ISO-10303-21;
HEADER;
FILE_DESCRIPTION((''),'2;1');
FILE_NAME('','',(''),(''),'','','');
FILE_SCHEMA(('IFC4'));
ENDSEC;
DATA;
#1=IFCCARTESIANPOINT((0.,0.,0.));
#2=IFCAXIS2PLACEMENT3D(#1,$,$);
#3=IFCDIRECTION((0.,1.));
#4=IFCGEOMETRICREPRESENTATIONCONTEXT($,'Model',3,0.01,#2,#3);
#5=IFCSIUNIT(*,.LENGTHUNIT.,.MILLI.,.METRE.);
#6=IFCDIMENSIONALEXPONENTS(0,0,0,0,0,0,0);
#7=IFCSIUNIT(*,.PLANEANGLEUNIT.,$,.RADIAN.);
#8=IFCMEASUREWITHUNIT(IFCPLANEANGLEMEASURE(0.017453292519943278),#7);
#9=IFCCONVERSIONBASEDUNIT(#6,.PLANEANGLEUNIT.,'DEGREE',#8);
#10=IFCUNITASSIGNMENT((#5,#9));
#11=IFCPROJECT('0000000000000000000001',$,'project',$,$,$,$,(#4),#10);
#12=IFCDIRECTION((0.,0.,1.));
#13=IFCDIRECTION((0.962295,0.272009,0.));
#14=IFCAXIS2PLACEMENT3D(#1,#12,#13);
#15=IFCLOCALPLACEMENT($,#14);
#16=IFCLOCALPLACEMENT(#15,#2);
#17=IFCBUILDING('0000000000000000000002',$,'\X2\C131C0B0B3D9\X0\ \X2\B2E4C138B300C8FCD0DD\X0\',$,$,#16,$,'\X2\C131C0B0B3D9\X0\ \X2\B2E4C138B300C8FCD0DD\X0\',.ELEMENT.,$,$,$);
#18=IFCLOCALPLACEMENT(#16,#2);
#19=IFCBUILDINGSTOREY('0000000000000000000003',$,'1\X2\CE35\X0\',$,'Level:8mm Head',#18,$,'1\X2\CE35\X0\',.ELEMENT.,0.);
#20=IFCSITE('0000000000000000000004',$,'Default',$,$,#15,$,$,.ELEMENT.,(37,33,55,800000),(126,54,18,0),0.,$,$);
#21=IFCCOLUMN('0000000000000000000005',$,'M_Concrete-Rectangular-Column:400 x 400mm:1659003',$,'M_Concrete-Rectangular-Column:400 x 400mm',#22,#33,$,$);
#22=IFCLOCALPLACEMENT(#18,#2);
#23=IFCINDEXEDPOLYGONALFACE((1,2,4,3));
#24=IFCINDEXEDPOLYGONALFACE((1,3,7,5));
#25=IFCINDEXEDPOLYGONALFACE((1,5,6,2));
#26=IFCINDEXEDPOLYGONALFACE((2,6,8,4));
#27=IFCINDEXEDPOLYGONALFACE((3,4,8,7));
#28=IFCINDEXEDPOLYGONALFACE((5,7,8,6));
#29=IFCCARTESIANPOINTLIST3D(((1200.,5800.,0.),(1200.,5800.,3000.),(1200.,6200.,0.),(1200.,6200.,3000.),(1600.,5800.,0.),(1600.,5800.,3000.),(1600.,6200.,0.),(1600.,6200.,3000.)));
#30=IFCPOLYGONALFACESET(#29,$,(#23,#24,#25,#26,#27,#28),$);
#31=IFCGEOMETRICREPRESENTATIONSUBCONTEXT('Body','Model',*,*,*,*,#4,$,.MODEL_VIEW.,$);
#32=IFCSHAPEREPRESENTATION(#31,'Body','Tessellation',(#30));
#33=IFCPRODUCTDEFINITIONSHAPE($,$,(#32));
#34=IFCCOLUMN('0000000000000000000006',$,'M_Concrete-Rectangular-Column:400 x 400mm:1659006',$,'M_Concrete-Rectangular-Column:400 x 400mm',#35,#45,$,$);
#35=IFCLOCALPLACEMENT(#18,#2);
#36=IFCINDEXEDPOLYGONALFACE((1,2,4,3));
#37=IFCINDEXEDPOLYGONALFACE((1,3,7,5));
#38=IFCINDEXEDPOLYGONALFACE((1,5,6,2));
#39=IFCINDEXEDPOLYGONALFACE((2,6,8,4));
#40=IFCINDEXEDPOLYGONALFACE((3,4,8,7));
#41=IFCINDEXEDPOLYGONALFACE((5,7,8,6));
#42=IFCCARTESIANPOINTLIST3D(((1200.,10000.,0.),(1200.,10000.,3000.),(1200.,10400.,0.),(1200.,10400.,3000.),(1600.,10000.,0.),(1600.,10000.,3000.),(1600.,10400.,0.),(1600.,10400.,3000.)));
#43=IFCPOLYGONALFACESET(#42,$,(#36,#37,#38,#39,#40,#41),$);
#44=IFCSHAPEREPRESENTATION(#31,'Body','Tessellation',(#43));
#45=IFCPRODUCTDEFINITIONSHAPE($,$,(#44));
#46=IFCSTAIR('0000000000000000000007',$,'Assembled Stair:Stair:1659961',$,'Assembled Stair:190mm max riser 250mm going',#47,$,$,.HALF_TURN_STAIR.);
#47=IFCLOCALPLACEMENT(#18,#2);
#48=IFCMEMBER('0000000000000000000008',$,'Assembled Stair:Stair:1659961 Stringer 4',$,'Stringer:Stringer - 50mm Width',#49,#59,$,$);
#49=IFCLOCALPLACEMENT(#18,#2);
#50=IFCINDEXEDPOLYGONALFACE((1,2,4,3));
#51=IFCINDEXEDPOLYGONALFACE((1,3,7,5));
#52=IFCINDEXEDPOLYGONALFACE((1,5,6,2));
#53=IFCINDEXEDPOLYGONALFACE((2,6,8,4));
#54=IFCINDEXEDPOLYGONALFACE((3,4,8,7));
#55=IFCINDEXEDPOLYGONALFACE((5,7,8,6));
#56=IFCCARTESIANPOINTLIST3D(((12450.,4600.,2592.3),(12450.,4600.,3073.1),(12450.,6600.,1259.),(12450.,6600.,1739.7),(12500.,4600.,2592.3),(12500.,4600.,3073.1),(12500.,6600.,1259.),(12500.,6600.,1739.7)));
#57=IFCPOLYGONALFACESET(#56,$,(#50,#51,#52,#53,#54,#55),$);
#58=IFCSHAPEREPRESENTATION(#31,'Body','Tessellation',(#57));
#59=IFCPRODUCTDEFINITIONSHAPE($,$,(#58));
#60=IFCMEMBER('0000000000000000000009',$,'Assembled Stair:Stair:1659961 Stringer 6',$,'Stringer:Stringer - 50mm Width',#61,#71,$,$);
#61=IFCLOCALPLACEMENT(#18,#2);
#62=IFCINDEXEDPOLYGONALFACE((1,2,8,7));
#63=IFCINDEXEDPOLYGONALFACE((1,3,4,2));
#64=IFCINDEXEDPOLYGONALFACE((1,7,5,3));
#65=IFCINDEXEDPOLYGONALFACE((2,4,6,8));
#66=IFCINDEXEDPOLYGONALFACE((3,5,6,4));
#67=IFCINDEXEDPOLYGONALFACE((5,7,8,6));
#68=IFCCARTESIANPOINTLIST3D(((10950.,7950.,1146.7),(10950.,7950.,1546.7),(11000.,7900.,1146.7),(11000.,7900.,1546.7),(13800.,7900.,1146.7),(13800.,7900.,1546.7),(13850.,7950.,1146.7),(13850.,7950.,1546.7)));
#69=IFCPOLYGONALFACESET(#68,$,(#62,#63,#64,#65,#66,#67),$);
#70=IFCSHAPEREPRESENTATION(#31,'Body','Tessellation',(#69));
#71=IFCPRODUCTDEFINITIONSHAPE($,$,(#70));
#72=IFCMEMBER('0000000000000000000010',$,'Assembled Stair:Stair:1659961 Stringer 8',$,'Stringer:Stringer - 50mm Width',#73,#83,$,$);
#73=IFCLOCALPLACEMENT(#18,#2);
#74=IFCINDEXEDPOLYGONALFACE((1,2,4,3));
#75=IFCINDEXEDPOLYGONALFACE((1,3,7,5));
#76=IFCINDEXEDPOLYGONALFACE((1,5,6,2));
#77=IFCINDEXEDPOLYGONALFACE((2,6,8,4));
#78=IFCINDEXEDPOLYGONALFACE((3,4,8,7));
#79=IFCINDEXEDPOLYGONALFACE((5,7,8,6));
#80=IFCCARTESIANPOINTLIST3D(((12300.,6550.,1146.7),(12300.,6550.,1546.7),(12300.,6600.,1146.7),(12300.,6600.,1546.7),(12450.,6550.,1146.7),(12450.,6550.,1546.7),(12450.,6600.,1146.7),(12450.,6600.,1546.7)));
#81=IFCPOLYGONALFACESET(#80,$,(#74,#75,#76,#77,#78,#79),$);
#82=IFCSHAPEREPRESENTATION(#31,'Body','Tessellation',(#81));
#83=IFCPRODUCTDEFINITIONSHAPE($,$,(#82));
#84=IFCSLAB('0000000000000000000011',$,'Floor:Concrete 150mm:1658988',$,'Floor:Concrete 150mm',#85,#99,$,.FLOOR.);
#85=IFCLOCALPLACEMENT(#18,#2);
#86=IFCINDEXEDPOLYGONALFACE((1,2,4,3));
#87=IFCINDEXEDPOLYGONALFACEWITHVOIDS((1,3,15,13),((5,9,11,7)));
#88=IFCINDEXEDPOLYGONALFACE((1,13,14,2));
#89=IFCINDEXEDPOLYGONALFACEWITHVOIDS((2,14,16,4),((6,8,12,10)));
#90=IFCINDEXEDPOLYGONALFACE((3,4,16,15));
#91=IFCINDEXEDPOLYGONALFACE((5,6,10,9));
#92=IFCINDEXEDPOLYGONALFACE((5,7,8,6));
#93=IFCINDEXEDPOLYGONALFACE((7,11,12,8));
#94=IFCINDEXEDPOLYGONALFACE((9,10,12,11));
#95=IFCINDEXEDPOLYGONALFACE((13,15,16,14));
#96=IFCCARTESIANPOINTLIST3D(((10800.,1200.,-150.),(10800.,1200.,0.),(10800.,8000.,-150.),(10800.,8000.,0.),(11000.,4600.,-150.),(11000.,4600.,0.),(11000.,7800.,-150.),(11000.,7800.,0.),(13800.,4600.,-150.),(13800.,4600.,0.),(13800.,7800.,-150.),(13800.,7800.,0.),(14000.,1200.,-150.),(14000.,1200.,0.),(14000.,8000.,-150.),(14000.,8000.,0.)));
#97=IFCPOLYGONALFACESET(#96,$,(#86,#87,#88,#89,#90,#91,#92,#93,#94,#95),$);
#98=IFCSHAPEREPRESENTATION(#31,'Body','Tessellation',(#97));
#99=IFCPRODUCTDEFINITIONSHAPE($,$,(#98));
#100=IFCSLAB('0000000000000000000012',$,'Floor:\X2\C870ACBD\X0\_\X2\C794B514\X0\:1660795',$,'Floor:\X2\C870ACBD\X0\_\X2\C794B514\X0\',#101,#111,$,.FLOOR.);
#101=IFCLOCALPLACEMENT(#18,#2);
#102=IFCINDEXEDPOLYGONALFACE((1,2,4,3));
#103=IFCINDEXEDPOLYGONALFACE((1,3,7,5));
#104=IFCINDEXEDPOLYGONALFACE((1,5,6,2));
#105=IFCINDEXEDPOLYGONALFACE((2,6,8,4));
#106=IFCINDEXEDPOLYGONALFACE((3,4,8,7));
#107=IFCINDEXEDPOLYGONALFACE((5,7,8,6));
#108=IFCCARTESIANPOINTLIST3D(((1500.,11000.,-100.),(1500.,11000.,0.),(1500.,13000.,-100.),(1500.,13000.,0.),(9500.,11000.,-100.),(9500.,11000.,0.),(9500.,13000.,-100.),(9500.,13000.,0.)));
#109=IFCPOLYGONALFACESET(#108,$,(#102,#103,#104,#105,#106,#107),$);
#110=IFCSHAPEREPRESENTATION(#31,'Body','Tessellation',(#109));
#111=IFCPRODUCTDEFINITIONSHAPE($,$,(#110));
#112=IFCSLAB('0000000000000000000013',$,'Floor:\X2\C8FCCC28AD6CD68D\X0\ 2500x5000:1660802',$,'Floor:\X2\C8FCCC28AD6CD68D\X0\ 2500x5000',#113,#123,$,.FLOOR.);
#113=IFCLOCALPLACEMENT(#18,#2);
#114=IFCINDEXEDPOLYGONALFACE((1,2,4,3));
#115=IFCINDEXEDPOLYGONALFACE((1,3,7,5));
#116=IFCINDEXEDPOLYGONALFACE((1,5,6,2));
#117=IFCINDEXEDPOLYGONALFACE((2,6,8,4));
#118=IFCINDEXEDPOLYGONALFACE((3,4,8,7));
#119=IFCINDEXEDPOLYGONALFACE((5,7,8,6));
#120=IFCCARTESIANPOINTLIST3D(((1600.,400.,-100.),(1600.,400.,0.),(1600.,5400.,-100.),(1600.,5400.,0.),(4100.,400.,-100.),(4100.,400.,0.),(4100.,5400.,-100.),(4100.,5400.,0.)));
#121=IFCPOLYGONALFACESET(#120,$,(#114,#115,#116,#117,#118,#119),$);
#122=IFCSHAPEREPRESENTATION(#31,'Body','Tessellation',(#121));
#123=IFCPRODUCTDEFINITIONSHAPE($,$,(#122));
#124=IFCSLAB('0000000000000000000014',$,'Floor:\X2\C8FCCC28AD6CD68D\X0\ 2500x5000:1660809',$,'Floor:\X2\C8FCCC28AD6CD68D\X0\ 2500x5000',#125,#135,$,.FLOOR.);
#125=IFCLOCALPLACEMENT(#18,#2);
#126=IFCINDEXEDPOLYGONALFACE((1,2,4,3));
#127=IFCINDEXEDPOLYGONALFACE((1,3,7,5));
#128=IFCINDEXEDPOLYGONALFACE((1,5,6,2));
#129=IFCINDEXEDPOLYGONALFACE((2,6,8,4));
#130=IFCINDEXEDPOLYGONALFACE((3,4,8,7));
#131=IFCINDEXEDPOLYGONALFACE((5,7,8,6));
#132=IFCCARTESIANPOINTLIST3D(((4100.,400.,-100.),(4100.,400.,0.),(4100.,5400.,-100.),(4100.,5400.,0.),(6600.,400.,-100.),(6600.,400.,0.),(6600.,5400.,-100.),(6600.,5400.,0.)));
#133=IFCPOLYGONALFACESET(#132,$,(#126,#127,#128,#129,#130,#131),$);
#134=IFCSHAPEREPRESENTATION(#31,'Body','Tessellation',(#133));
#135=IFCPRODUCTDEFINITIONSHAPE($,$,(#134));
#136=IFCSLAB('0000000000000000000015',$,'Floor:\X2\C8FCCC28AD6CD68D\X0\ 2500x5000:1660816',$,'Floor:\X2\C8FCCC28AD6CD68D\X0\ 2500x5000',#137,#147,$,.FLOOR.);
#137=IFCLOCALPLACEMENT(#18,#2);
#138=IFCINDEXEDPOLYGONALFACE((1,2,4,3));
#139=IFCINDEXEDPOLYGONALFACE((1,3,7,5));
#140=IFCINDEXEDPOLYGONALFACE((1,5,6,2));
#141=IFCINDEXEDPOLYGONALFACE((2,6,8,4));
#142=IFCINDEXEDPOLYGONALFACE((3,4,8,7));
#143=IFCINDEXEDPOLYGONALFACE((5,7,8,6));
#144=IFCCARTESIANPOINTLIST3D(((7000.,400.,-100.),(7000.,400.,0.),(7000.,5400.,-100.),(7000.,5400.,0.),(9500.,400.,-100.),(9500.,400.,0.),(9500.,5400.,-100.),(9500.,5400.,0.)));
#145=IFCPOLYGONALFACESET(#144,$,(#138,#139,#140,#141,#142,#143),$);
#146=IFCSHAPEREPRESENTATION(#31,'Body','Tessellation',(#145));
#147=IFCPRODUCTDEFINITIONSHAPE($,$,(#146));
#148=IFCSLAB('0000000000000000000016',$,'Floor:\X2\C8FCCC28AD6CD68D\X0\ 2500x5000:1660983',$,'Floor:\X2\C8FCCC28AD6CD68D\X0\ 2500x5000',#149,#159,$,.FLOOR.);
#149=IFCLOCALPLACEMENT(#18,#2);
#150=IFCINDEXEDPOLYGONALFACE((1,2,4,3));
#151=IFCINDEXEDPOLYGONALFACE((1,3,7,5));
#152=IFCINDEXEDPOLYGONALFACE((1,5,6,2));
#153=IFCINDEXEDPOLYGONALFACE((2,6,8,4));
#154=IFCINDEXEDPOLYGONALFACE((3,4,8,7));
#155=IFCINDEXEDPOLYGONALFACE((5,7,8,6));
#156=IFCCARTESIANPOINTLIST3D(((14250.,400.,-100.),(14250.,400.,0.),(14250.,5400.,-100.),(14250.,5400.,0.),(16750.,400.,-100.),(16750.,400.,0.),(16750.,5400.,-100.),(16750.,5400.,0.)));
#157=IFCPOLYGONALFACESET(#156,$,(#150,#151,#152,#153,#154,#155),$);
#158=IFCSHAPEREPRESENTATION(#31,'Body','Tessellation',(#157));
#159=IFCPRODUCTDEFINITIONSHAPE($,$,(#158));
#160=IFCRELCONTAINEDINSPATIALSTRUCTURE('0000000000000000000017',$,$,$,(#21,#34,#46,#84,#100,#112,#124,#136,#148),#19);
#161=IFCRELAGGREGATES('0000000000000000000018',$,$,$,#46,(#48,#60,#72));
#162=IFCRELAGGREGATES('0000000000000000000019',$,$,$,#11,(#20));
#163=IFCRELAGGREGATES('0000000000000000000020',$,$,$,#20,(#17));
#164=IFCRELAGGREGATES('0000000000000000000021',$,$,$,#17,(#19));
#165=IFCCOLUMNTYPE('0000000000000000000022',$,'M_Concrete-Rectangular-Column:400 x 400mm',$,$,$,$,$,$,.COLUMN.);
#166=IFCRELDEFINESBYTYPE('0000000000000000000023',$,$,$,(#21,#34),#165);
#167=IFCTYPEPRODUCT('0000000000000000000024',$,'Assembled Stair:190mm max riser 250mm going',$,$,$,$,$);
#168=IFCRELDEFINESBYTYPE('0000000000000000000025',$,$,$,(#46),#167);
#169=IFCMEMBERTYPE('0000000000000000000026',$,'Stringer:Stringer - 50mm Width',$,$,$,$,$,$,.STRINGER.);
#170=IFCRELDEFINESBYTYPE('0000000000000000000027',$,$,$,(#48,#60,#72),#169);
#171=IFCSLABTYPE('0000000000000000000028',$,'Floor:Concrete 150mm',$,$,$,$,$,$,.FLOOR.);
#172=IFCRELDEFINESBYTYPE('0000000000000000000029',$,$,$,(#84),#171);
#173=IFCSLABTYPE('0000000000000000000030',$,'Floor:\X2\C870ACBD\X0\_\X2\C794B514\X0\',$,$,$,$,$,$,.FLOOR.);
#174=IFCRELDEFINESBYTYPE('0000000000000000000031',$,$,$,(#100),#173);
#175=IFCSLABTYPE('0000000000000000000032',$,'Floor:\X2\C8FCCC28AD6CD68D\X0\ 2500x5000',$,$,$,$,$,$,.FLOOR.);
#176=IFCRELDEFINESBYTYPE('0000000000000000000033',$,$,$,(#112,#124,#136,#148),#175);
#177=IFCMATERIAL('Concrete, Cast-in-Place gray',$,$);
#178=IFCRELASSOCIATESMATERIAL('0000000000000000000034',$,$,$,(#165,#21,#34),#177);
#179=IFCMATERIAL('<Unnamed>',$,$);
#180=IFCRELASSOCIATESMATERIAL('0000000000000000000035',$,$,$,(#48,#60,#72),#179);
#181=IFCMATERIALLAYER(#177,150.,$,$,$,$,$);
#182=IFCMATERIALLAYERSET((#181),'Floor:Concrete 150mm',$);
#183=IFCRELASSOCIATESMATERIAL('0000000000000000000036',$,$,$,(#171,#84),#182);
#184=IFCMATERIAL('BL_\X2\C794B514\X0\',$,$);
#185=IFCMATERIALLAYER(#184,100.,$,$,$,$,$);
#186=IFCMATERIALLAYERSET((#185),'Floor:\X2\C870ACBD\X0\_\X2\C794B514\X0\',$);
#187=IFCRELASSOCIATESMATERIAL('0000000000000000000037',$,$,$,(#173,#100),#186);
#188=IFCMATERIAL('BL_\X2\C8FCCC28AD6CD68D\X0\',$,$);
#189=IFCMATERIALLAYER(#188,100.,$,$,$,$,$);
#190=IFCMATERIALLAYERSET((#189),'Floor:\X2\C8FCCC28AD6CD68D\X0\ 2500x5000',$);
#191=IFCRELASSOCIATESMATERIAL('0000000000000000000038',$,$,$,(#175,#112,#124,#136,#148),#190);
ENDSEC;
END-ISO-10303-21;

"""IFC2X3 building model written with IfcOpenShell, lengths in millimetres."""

from ifc_helpers import new_model, entity, si_unit, converted_unit, direction, frame, frame_2d, origin, origin_2d_with_axis, place, context, subcontext, project, spatial, polyline, rectangle, outline, extrude, boolean, source, transform, mapped, material, layer, layer_set, layer_usage, type_object, type_shapes, element, aggregate, save


model = new_model("IFC2X3")

# Units and contexts
model_context = context("Model", 3, precision=0.01, world=origin(), true_north=direction((0.0, 1.0)))
body_context = subcontext(model_context, "Body", "Model", "MODEL_VIEW")
ifc_project = project(units=[si_unit("LENGTHUNIT", "METRE", prefix="MILLI"), converted_unit("PLANEANGLEUNIT", "DEGREE", entity("IfcPlaneAngleMeasure", 0.017453292519943278), si_unit("PLANEANGLEUNIT", "RADIAN"), dimensions=[0, 0, 0, 0, 0, 0, 0])], contexts=[model_context])

# Site, building, storey
site_placement = place(None, frame((0.0, 0.0, 0.0), z_axis=(0.0, 0.0, 1.0), x_axis=(0.962295, 0.272009, 0.0)))
site = spatial("IfcSite", under=ifc_project, at=site_placement, Name="Default", CompositionType="ELEMENT", RefLatitude=(37, 33, 55, 800000), RefLongitude=(126, 54, 18, 0), RefElevation=0.0)
building_placement = place(site_placement, origin())
building = spatial("IfcBuilding", under=site, at=building_placement, Name="성산동 다세대주택", LongName="성산동 다세대주택", CompositionType="ELEMENT")
storey_placement = place(building_placement, origin())
storey = spatial("IfcBuildingStorey", under=building, at=storey_placement, Name="1층", ObjectType="Level:8mm Head", LongName="1층", CompositionType="ELEMENT", Elevation=0.0)

# Columns
ifc_material_1 = material(Name="Concrete, Cast-in-Place gray")
column_type = type_object("IfcColumnType", Name="M_Concrete-Rectangular-Column:400 x 400mm", PredefinedType="COLUMN", material=ifc_material_1)
shared_shape = source(origin(), body_context, "Body", "SweptSolid", [
    extrude(rectangle(XDim=400.0, YDim=400.0, at=origin_2d_with_axis()), frame((0.0, 0.0, 0.0), z_axis=(0.0, 0.0, 1.0), x_axis=(-1.0, 0.0, 0.0)), (0.0, 0.0, 1.0), 3000.0),
])
type_shapes(column_type, [shared_shape])
for number, where, name in (
    (1, (1400.0, 6000.0, 0.0), "M_Concrete-Rectangular-Column:400 x 400mm:1659003"),
    (2, (1400.0, 10200.0, 0.0), "M_Concrete-Rectangular-Column:400 x 400mm:1659006"),
):
    element("IfcColumn", number, at=place(storey_placement, frame(where)), inside=storey, type_object=column_type, material=ifc_material_1, Name=name, ObjectType="M_Concrete-Rectangular-Column:400 x 400mm", context=body_context, shape_type="MappedRepresentation", body=[
        mapped(shared_shape, transform((0.0, 0.0, 0.0), scale=1.0)),
    ])

# Stair, members
type_product = type_object("IfcTypeProduct", Name="Assembled Stair:190mm max riser 250mm going")
stair_placement = place(storey_placement, origin())
stair = element("IfcStair", 3, at=stair_placement, inside=storey, type_object=type_product, Name="Assembled Stair:Stair:1659961", ObjectType="Assembled Stair:190mm max riser 250mm going", ShapeType="HALF_TURN_STAIR")
ifc_material_2 = material(Name="<Unnamed>")
member_type = type_object("IfcMemberType", Name="Stringer:Stringer - 50mm Width", PredefinedType="STRINGER")
member_1_placement = place(stair_placement, origin())
member_1 = element("IfcMember", 4, at=member_1_placement, type_object=member_type, material=ifc_material_2, Name="Assembled Stair:Stair:1659961 Stringer 4", ObjectType="Stringer:Stringer - 50mm Width", context=body_context, shape_type="SweptSolid", body=[
    extrude(outline(polyline([(-1068.5, -200.0), (1335.2, -200.0), (1068.5, 200.0), (-1335.2, 200.0), (-1068.5, -200.0)])), frame((12450.0, 5600.0, 2166.0), z_axis=(1.0, 0.0, 0.0), x_axis=(0.0, -0.83205, 0.5547)), (0.0, 0.0, 1.0), 50.0),
])
member_2_placement = place(stair_placement, origin())
member_2 = element("IfcMember", 5, at=member_2_placement, type_object=member_type, material=ifc_material_2, Name="Assembled Stair:Stair:1659961 Stringer 6", ObjectType="Stringer:Stringer - 50mm Width", context=body_context, shape_type="SweptSolid", body=[
    extrude(outline(polyline([(-1450.0, -25.0), (1450.0, -25.0), (1400.0, 25.0), (-1400.0, 25.0), (-1450.0, -25.0)])), frame((12400.0, 7925.0, 1146.7), z_axis=(0.0, 0.0, 1.0), x_axis=(-1.0, 0.0, 0.0)), (0.0, 0.0, 1.0), 400.0),
])
member_3_placement = place(stair_placement, origin())
member_3 = element("IfcMember", 6, at=member_3_placement, type_object=member_type, material=ifc_material_2, Name="Assembled Stair:Stair:1659961 Stringer 8", ObjectType="Stringer:Stringer - 50mm Width", context=body_context, shape_type="SweptSolid", body=[
    extrude(rectangle(XDim=150.0, YDim=50.0, at=origin_2d_with_axis()), frame((12375.0, 6575.0, 1146.7)), (0.0, 0.0, 1.0), 400.0),
])

# Slab, opening
ifc_layer_1 = layer(ifc_material_1, 150.0)
ifc_layer_set_1 = layer_set([ifc_layer_1], Name="Floor:Concrete 150mm")
ifc_layer_usage_1 = layer_usage(ifc_layer_set_1, "AXIS3", "POSITIVE", 0.0)
slab_type_1 = type_object("IfcSlabType", Name="Floor:Concrete 150mm", PredefinedType="FLOOR", material=ifc_layer_set_1)
slab_1_placement = place(storey_placement, origin())
slab_1 = element("IfcSlab", 7, at=slab_1_placement, inside=storey, type_object=slab_type_1, material=ifc_layer_usage_1, Name="Floor:Concrete 150mm:1658988", ObjectType="Floor:Concrete 150mm", PredefinedType="FLOOR", context=body_context, shape_type="SweptSolid", body=[
    boolean("DIFFERENCE", extrude(rectangle(XDim=6800.0, YDim=3200.0, at=origin_2d_with_axis()), frame((12400.0, 4600.0, 0.0), z_axis=(0.0, 0.0, -1.0), x_axis=(0.0, 1.0, 0.0)), (0.0, 0.0, 1.0), 150.0), extrude(rectangle(XDim=3200.0, YDim=2800.0, at=frame_2d((0.0, 0.0), x_axis=(1.0, 0.0))), frame((12400.0, 6200.0, -150.0), z_axis=(0.0, 0.0, 1.0), x_axis=(0.0, 1.0, 0.0)), (0.0, 0.0, 1.0), 150.0)),
])
opening_placement = place(slab_1_placement, origin())
element("IfcOpeningElement", 8, at=opening_placement, cuts=slab_1, ObjectType="Opening", context=body_context, shape_type="SweptSolid", body=[
    extrude(rectangle(XDim=2800.0, YDim=3200.0, at=frame_2d((0.0, 0.0), x_axis=(1.0, 0.0))), frame((12400.0, 6200.0, 0.0), z_axis=(0.0, 0.0, -1.0), x_axis=(-1.0, 0.0, 0.0)), (0.0, 0.0, 1.0), 150.0),
])

# Slabs
ifc_material_3 = material(Name="BL_잔디")
ifc_layer_2 = layer(ifc_material_3, 100.0)
ifc_layer_set_2 = layer_set([ifc_layer_2], Name="Floor:조경_잔디")
ifc_layer_usage_2 = layer_usage(ifc_layer_set_2, "AXIS3", "POSITIVE", 0.0)
slab_type_2 = type_object("IfcSlabType", Name="Floor:조경_잔디", PredefinedType="FLOOR", material=ifc_layer_set_2)
slab_2_placement = place(storey_placement, origin())
element("IfcSlab", 9, at=slab_2_placement, inside=storey, type_object=slab_type_2, material=ifc_layer_usage_2, Name="Floor:조경_잔디:1660795", ObjectType="Floor:조경_잔디", PredefinedType="FLOOR", context=body_context, shape_type="SweptSolid", body=[
    extrude(rectangle(XDim=2000.0, YDim=8000.0, at=frame_2d((0.0, 0.0), x_axis=(1.0, 0.0))), frame((5500.0, 12000.0, 0.0), z_axis=(0.0, 0.0, -1.0), x_axis=(0.0, 1.0, 0.0)), (0.0, 0.0, 1.0), 100.0),
])
ifc_material_4 = material(Name="BL_주차구획")
ifc_layer_3 = layer(ifc_material_4, 100.0)
ifc_layer_set_3 = layer_set([ifc_layer_3], Name="Floor:주차구획 2500x5000")
ifc_layer_usage_3 = layer_usage(ifc_layer_set_3, "AXIS3", "POSITIVE", 0.0)
slab_type_3 = type_object("IfcSlabType", Name="Floor:주차구획 2500x5000", PredefinedType="FLOOR", material=ifc_layer_set_3)
slab_3_placement = place(storey_placement, origin())
element("IfcSlab", 10, at=slab_3_placement, inside=storey, type_object=slab_type_3, material=ifc_layer_usage_3, Name="Floor:주차구획 2500x5000:1660802", ObjectType="Floor:주차구획 2500x5000", PredefinedType="FLOOR", context=body_context, shape_type="SweptSolid", body=[
    extrude(rectangle(XDim=5000.0, YDim=2500.0, at=origin_2d_with_axis()), frame((2850.0, 2900.0, 0.0), z_axis=(0.0, 0.0, -1.0), x_axis=(0.0, 1.0, 0.0)), (0.0, 0.0, 1.0), 100.0),
])
ifc_layer_usage_4 = layer_usage(ifc_layer_set_3, "AXIS3", "POSITIVE", 0.0)
slab_4_placement = place(storey_placement, origin())
element("IfcSlab", 11, at=slab_4_placement, inside=storey, type_object=slab_type_3, material=ifc_layer_usage_4, Name="Floor:주차구획 2500x5000:1660809", ObjectType="Floor:주차구획 2500x5000", PredefinedType="FLOOR", context=body_context, shape_type="SweptSolid", body=[
    extrude(rectangle(XDim=5000.0, YDim=2500.0, at=frame_2d((0.0, 0.0), x_axis=(1.0, 0.0))), frame((5350.0, 2900.0, 0.0), z_axis=(0.0, 0.0, -1.0), x_axis=(0.0, 1.0, 0.0)), (0.0, 0.0, 1.0), 100.0),
])
ifc_layer_usage_5 = layer_usage(ifc_layer_set_3, "AXIS3", "POSITIVE", 0.0)
slab_5_placement = place(storey_placement, origin())
element("IfcSlab", 12, at=slab_5_placement, inside=storey, type_object=slab_type_3, material=ifc_layer_usage_5, Name="Floor:주차구획 2500x5000:1660816", ObjectType="Floor:주차구획 2500x5000", PredefinedType="FLOOR", context=body_context, shape_type="SweptSolid", body=[
    extrude(rectangle(XDim=5000.0, YDim=2500.0, at=origin_2d_with_axis()), frame((8250.0, 2900.0, 0.0), z_axis=(0.0, 0.0, -1.0), x_axis=(0.0, 1.0, 0.0)), (0.0, 0.0, 1.0), 100.0),
])
ifc_layer_usage_6 = layer_usage(ifc_layer_set_3, "AXIS3", "POSITIVE", 0.0)
slab_6_placement = place(storey_placement, origin())
element("IfcSlab", 13, at=slab_6_placement, inside=storey, type_object=slab_type_3, material=ifc_layer_usage_6, Name="Floor:주차구획 2500x5000:1660983", ObjectType="Floor:주차구획 2500x5000", PredefinedType="FLOOR", context=body_context, shape_type="SweptSolid", body=[
    extrude(rectangle(XDim=5000.0, YDim=2500.0, at=frame_2d((0.0, 0.0), x_axis=(1.0, 0.0))), frame((15500.0, 2900.0, 0.0), z_axis=(0.0, 0.0, -1.0), x_axis=(0.0, 1.0, 0.0)), (0.0, 0.0, 1.0), 100.0),
])

aggregate(stair, [member_1, member_2, member_3])

save(model, "model.ifc")
